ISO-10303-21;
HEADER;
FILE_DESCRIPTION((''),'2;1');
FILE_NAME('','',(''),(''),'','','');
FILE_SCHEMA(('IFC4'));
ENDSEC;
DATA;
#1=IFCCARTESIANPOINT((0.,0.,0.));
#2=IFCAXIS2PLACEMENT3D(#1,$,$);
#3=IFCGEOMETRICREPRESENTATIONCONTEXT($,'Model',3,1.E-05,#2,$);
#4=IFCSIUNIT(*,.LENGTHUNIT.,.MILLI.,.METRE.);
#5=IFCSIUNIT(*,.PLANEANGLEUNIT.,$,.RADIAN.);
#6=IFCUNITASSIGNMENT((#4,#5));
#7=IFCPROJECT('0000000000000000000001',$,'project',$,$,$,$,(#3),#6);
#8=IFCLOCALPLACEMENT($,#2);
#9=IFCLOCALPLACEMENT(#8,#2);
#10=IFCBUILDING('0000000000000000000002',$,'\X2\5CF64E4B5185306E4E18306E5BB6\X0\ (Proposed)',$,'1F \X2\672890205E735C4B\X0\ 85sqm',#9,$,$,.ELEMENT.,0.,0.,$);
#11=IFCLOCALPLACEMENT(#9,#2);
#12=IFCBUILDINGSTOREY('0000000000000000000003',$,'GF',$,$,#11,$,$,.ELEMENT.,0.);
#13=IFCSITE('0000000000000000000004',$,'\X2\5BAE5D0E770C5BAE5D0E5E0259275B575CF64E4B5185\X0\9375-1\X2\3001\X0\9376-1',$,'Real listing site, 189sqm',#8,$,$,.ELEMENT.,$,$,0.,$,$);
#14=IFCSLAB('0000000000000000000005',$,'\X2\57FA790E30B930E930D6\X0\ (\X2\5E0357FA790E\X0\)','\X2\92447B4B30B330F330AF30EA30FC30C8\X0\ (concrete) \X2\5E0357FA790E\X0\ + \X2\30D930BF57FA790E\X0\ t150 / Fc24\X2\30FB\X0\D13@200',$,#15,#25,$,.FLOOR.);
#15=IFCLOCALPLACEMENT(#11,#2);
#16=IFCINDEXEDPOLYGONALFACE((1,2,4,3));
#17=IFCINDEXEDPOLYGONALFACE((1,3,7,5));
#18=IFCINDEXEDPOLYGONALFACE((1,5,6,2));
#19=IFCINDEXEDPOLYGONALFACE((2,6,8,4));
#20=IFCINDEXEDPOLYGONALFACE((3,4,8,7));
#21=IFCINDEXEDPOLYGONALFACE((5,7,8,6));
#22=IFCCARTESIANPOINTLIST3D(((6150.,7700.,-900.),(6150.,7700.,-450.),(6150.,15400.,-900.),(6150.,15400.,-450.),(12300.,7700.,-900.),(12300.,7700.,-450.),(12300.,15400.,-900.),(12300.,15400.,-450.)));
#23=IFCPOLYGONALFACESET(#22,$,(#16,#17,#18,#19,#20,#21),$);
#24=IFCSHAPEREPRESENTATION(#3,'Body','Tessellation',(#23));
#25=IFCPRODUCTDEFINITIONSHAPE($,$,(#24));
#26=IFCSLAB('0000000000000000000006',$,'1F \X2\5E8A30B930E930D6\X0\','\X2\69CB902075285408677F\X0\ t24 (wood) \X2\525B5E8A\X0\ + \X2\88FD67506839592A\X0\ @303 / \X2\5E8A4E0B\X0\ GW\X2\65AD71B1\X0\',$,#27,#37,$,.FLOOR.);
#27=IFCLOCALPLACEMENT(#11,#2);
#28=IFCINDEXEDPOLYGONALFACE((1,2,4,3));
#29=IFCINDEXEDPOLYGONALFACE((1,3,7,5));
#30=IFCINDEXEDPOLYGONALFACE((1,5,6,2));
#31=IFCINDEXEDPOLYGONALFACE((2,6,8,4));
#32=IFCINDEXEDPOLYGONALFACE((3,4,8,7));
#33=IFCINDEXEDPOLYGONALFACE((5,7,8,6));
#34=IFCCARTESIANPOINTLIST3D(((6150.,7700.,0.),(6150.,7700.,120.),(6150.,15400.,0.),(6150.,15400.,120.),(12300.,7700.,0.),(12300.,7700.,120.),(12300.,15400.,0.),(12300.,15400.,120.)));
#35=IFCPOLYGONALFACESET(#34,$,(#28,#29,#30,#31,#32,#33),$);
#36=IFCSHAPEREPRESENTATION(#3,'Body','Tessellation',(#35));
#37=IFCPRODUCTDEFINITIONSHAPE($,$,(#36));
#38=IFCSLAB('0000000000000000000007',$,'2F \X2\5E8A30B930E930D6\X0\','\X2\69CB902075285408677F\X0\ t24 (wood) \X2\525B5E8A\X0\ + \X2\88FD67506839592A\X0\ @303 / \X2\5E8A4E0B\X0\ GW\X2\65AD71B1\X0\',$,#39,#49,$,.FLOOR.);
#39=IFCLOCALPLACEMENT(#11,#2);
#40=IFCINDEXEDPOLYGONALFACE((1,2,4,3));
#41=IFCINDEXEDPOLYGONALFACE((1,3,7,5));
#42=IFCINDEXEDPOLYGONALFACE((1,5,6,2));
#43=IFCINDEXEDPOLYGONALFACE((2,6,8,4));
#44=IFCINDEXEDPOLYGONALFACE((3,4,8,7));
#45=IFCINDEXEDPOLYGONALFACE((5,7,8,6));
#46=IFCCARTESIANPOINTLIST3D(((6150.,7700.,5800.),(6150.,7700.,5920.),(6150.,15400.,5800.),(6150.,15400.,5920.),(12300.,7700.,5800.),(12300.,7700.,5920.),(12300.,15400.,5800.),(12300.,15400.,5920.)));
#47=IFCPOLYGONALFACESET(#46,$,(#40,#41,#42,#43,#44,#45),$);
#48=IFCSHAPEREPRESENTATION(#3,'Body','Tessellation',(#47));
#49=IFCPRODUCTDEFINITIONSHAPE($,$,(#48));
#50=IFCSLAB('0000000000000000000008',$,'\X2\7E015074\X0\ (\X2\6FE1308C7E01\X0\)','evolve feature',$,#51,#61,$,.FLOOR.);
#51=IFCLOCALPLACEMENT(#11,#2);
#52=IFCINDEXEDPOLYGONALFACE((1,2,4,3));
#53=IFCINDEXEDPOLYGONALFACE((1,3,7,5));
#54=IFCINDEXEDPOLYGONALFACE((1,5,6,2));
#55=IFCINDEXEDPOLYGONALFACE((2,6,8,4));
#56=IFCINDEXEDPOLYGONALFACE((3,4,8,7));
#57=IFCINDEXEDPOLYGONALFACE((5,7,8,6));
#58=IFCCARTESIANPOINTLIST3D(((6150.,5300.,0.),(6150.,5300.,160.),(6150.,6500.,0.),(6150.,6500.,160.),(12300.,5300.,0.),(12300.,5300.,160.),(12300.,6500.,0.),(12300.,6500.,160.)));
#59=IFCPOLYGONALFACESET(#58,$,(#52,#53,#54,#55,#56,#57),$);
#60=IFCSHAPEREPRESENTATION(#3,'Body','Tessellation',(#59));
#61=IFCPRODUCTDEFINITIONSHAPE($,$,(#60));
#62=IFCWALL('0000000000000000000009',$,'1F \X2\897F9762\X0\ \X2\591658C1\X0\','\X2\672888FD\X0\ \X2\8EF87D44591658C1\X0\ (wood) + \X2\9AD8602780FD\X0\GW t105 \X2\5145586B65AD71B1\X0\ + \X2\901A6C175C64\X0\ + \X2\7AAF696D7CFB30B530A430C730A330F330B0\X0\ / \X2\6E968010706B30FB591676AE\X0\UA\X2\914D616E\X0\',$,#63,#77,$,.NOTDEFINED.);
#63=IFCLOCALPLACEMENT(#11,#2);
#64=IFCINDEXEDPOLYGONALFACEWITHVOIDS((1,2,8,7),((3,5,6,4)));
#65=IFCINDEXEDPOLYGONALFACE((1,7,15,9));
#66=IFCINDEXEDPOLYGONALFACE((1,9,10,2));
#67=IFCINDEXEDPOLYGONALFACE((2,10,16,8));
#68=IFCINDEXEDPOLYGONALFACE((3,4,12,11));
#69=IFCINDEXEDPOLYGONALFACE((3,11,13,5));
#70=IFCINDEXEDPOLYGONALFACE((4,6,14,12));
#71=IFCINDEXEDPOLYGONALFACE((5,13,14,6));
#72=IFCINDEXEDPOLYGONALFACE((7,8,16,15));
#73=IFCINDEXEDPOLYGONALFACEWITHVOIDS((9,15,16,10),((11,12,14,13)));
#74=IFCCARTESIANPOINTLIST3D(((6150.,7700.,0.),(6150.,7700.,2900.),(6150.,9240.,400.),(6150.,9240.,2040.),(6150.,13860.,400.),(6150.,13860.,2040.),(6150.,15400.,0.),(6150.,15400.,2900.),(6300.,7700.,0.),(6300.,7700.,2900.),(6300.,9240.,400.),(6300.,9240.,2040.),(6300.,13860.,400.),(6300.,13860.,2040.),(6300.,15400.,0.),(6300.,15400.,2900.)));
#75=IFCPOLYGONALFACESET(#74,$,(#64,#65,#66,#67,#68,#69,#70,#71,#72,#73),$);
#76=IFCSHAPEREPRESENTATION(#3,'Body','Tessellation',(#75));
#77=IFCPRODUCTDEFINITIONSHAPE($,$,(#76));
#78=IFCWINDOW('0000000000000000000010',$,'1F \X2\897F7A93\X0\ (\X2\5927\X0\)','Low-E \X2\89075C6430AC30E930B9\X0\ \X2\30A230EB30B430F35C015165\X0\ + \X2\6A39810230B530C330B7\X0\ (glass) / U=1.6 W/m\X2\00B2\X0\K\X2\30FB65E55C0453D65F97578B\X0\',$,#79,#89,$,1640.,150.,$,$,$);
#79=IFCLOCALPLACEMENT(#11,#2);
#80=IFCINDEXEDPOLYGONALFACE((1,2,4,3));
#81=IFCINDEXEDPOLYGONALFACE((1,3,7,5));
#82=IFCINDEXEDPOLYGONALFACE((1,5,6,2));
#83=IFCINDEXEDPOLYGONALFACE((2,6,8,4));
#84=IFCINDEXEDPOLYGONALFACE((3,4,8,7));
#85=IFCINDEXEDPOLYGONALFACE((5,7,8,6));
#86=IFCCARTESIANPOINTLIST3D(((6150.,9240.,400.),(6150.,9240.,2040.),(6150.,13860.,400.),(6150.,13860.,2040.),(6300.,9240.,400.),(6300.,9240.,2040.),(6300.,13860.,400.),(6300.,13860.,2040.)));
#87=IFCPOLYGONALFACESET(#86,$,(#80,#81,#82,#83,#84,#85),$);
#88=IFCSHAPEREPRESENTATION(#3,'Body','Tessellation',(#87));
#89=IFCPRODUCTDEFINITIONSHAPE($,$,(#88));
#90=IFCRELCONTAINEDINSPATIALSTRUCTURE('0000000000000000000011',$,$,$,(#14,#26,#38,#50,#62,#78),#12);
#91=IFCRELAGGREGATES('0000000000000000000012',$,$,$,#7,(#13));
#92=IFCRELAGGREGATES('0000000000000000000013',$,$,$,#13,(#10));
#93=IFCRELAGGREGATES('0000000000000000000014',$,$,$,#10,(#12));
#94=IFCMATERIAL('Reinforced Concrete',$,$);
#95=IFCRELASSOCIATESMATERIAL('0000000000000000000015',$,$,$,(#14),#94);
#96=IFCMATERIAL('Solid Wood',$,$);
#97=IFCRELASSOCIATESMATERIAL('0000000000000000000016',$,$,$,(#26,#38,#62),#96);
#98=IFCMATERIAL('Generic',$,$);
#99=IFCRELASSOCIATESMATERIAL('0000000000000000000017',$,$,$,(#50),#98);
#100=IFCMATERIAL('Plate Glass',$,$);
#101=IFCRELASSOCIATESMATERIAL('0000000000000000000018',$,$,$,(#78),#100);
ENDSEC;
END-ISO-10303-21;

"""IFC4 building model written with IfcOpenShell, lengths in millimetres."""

from ifc_helpers import new_model, si_unit, frame, frame_2d, origin, place, context, project, spatial, rectangle, extrude, material, element, fill, save


model = new_model("IFC4")

# Units and contexts
model_context = context("Model", 3, precision=1e-05, world=origin())
ifc_project = project(units=[si_unit("LENGTHUNIT", "METRE", prefix="MILLI"), si_unit("PLANEANGLEUNIT", "RADIAN")], contexts=[model_context])

# Site, building, storey
site_placement = place(None, origin())
site = spatial("IfcSite", under=ifc_project, at=site_placement, Name="宮崎県宮崎市大字島之内9375-1、9376-1", ObjectType="Real listing site, 189sqm", CompositionType="ELEMENT", RefElevation=0.0)
building_placement = place(site_placement, origin())
building = spatial("IfcBuilding", under=site, at=building_placement, Name="島之内の丘の家 (Proposed)", ObjectType="1F 木造平屋 85sqm", CompositionType="ELEMENT", ElevationOfRefHeight=0.0, ElevationOfTerrain=0.0)
storey_placement = place(building_placement, origin())
storey = spatial("IfcBuildingStorey", under=building, at=storey_placement, Name="GF", CompositionType="ELEMENT", Elevation=0.0)

# Slabs
ifc_material_1 = material(Name="Reinforced Concrete")
slab_1_placement = place(storey_placement, frame((3075.0, 3850.0, -450.0)))
element("IfcSlab", 1, at=slab_1_placement, inside=storey, material=ifc_material_1, Name="基礎スラブ (布基礎)", Description="鉄筋コンクリート (concrete) 布基礎 + ベタ基礎 t150 / Fc24・D13@200", PredefinedType="FLOOR", context=model_context, shape_type="SweptSolid", body=[
    extrude(rectangle(XDim=6150.0, YDim=7700.0, at=frame_2d((3075.0, 3850.0))), frame((3075.0, 3850.0, -450.0)), (0.0, 0.0, 1.0), 450.0),
])
ifc_material_2 = material(Name="Solid Wood")
slab_2_placement = place(storey_placement, frame((3075.0, 3850.0, 0.0)))
element("IfcSlab", 2, at=slab_2_placement, inside=storey, material=ifc_material_2, Name="1F 床スラブ", Description="構造用合板 t24 (wood) 剛床 + 製材根太 @303 / 床下 GW断熱", PredefinedType="FLOOR", context=model_context, shape_type="SweptSolid", body=[
    extrude(rectangle(XDim=6150.0, YDim=7700.0, at=frame_2d((3075.0, 3850.0))), frame((3075.0, 3850.0, 0.0)), (0.0, 0.0, 1.0), 120.0),
])
slab_3_placement = place(storey_placement, frame((3075.0, 3850.0, 2900.0)))
element("IfcSlab", 3, at=slab_3_placement, inside=storey, material=ifc_material_2, Name="2F 床スラブ", Description="構造用合板 t24 (wood) 剛床 + 製材根太 @303 / 床下 GW断熱", PredefinedType="FLOOR", context=model_context, shape_type="SweptSolid", body=[
    extrude(rectangle(XDim=6150.0, YDim=7700.0, at=frame_2d((3075.0, 3850.0))), frame((3075.0, 3850.0, 2900.0)), (0.0, 0.0, 1.0), 120.0),
])
ifc_material_3 = material(Name="Generic")
slab_4_placement = place(storey_placement, frame((3075.0, 2650.0, 0.0)))
element("IfcSlab", 4, at=slab_4_placement, inside=storey, material=ifc_material_3, Name="縁側 (濡れ縁)", Description="evolve feature", PredefinedType="FLOOR", context=model_context, shape_type="SweptSolid", body=[
    extrude(rectangle(XDim=6150.0, YDim=1200.0, at=frame_2d((3075.0, 600.0))), frame((3075.0, 2650.0, 0.0)), (0.0, 0.0, 1.0), 160.0),
])

# Shared definitions
ifc_material_4 = material(Name="Plate Glass")

# Wall, opening, window
wall_1_placement = place(storey_placement, frame((3075.0, 3850.0, 0.0)))
wall_1 = element("IfcWall", 5, at=wall_1_placement, inside=storey, material=ifc_material_2, Name="1F 西面 外壁", Description="木製 軸組外壁 (wood) + 高性能GW t105 充填断熱 + 通気層 + 窯業系サイディング / 準耐火・外皮UA配慮", PredefinedType="NOTDEFINED", context=model_context, shape_type="SweptSolid", body=[
    extrude(rectangle(XDim=150.0, YDim=7700.0, at=frame_2d((75.0, 3850.0))), frame((3075.0, 3850.0, 0.0)), (0.0, 0.0, 1.0), 2900.0),
])
opening_1_placement = place(storey_placement, frame((3075.0, 4620.0, 200.0)))
opening_1 = element("IfcOpeningElement", 6, at=opening_1_placement, cuts=wall_1, PredefinedType="NOTDEFINED", context=model_context, shape_type="SweptSolid", body=[
    extrude(rectangle(XDim=150.0, YDim=4620.0, at=frame_2d((75.0, 2310.0))), frame((3075.0, 4620.0, 200.0)), (0.0, 0.0, 1.0), 1640.0),
])
window_1_placement = place(storey_placement, frame((3075.0, 4620.0, 200.0)))
window_1 = element("IfcWindow", 7, at=window_1_placement, inside=storey, material=ifc_material_4, Name="1F 西窓 (大)", Description="Low-E 複層ガラス アルゴン封入 + 樹脂サッシ (glass) / U=1.6 W/m²K・日射取得型", OverallHeight=1640.0, OverallWidth=150.0, context=model_context, shape_type="SweptSolid", body=[
    extrude(rectangle(XDim=150.0, YDim=4620.0, at=frame_2d((75.0, 2310.0))), frame((3075.0, 4620.0, 200.0)), (0.0, 0.0, 1.0), 1640.0),
])
fill(opening_1, window_1)

save(model, "model.ifc")
